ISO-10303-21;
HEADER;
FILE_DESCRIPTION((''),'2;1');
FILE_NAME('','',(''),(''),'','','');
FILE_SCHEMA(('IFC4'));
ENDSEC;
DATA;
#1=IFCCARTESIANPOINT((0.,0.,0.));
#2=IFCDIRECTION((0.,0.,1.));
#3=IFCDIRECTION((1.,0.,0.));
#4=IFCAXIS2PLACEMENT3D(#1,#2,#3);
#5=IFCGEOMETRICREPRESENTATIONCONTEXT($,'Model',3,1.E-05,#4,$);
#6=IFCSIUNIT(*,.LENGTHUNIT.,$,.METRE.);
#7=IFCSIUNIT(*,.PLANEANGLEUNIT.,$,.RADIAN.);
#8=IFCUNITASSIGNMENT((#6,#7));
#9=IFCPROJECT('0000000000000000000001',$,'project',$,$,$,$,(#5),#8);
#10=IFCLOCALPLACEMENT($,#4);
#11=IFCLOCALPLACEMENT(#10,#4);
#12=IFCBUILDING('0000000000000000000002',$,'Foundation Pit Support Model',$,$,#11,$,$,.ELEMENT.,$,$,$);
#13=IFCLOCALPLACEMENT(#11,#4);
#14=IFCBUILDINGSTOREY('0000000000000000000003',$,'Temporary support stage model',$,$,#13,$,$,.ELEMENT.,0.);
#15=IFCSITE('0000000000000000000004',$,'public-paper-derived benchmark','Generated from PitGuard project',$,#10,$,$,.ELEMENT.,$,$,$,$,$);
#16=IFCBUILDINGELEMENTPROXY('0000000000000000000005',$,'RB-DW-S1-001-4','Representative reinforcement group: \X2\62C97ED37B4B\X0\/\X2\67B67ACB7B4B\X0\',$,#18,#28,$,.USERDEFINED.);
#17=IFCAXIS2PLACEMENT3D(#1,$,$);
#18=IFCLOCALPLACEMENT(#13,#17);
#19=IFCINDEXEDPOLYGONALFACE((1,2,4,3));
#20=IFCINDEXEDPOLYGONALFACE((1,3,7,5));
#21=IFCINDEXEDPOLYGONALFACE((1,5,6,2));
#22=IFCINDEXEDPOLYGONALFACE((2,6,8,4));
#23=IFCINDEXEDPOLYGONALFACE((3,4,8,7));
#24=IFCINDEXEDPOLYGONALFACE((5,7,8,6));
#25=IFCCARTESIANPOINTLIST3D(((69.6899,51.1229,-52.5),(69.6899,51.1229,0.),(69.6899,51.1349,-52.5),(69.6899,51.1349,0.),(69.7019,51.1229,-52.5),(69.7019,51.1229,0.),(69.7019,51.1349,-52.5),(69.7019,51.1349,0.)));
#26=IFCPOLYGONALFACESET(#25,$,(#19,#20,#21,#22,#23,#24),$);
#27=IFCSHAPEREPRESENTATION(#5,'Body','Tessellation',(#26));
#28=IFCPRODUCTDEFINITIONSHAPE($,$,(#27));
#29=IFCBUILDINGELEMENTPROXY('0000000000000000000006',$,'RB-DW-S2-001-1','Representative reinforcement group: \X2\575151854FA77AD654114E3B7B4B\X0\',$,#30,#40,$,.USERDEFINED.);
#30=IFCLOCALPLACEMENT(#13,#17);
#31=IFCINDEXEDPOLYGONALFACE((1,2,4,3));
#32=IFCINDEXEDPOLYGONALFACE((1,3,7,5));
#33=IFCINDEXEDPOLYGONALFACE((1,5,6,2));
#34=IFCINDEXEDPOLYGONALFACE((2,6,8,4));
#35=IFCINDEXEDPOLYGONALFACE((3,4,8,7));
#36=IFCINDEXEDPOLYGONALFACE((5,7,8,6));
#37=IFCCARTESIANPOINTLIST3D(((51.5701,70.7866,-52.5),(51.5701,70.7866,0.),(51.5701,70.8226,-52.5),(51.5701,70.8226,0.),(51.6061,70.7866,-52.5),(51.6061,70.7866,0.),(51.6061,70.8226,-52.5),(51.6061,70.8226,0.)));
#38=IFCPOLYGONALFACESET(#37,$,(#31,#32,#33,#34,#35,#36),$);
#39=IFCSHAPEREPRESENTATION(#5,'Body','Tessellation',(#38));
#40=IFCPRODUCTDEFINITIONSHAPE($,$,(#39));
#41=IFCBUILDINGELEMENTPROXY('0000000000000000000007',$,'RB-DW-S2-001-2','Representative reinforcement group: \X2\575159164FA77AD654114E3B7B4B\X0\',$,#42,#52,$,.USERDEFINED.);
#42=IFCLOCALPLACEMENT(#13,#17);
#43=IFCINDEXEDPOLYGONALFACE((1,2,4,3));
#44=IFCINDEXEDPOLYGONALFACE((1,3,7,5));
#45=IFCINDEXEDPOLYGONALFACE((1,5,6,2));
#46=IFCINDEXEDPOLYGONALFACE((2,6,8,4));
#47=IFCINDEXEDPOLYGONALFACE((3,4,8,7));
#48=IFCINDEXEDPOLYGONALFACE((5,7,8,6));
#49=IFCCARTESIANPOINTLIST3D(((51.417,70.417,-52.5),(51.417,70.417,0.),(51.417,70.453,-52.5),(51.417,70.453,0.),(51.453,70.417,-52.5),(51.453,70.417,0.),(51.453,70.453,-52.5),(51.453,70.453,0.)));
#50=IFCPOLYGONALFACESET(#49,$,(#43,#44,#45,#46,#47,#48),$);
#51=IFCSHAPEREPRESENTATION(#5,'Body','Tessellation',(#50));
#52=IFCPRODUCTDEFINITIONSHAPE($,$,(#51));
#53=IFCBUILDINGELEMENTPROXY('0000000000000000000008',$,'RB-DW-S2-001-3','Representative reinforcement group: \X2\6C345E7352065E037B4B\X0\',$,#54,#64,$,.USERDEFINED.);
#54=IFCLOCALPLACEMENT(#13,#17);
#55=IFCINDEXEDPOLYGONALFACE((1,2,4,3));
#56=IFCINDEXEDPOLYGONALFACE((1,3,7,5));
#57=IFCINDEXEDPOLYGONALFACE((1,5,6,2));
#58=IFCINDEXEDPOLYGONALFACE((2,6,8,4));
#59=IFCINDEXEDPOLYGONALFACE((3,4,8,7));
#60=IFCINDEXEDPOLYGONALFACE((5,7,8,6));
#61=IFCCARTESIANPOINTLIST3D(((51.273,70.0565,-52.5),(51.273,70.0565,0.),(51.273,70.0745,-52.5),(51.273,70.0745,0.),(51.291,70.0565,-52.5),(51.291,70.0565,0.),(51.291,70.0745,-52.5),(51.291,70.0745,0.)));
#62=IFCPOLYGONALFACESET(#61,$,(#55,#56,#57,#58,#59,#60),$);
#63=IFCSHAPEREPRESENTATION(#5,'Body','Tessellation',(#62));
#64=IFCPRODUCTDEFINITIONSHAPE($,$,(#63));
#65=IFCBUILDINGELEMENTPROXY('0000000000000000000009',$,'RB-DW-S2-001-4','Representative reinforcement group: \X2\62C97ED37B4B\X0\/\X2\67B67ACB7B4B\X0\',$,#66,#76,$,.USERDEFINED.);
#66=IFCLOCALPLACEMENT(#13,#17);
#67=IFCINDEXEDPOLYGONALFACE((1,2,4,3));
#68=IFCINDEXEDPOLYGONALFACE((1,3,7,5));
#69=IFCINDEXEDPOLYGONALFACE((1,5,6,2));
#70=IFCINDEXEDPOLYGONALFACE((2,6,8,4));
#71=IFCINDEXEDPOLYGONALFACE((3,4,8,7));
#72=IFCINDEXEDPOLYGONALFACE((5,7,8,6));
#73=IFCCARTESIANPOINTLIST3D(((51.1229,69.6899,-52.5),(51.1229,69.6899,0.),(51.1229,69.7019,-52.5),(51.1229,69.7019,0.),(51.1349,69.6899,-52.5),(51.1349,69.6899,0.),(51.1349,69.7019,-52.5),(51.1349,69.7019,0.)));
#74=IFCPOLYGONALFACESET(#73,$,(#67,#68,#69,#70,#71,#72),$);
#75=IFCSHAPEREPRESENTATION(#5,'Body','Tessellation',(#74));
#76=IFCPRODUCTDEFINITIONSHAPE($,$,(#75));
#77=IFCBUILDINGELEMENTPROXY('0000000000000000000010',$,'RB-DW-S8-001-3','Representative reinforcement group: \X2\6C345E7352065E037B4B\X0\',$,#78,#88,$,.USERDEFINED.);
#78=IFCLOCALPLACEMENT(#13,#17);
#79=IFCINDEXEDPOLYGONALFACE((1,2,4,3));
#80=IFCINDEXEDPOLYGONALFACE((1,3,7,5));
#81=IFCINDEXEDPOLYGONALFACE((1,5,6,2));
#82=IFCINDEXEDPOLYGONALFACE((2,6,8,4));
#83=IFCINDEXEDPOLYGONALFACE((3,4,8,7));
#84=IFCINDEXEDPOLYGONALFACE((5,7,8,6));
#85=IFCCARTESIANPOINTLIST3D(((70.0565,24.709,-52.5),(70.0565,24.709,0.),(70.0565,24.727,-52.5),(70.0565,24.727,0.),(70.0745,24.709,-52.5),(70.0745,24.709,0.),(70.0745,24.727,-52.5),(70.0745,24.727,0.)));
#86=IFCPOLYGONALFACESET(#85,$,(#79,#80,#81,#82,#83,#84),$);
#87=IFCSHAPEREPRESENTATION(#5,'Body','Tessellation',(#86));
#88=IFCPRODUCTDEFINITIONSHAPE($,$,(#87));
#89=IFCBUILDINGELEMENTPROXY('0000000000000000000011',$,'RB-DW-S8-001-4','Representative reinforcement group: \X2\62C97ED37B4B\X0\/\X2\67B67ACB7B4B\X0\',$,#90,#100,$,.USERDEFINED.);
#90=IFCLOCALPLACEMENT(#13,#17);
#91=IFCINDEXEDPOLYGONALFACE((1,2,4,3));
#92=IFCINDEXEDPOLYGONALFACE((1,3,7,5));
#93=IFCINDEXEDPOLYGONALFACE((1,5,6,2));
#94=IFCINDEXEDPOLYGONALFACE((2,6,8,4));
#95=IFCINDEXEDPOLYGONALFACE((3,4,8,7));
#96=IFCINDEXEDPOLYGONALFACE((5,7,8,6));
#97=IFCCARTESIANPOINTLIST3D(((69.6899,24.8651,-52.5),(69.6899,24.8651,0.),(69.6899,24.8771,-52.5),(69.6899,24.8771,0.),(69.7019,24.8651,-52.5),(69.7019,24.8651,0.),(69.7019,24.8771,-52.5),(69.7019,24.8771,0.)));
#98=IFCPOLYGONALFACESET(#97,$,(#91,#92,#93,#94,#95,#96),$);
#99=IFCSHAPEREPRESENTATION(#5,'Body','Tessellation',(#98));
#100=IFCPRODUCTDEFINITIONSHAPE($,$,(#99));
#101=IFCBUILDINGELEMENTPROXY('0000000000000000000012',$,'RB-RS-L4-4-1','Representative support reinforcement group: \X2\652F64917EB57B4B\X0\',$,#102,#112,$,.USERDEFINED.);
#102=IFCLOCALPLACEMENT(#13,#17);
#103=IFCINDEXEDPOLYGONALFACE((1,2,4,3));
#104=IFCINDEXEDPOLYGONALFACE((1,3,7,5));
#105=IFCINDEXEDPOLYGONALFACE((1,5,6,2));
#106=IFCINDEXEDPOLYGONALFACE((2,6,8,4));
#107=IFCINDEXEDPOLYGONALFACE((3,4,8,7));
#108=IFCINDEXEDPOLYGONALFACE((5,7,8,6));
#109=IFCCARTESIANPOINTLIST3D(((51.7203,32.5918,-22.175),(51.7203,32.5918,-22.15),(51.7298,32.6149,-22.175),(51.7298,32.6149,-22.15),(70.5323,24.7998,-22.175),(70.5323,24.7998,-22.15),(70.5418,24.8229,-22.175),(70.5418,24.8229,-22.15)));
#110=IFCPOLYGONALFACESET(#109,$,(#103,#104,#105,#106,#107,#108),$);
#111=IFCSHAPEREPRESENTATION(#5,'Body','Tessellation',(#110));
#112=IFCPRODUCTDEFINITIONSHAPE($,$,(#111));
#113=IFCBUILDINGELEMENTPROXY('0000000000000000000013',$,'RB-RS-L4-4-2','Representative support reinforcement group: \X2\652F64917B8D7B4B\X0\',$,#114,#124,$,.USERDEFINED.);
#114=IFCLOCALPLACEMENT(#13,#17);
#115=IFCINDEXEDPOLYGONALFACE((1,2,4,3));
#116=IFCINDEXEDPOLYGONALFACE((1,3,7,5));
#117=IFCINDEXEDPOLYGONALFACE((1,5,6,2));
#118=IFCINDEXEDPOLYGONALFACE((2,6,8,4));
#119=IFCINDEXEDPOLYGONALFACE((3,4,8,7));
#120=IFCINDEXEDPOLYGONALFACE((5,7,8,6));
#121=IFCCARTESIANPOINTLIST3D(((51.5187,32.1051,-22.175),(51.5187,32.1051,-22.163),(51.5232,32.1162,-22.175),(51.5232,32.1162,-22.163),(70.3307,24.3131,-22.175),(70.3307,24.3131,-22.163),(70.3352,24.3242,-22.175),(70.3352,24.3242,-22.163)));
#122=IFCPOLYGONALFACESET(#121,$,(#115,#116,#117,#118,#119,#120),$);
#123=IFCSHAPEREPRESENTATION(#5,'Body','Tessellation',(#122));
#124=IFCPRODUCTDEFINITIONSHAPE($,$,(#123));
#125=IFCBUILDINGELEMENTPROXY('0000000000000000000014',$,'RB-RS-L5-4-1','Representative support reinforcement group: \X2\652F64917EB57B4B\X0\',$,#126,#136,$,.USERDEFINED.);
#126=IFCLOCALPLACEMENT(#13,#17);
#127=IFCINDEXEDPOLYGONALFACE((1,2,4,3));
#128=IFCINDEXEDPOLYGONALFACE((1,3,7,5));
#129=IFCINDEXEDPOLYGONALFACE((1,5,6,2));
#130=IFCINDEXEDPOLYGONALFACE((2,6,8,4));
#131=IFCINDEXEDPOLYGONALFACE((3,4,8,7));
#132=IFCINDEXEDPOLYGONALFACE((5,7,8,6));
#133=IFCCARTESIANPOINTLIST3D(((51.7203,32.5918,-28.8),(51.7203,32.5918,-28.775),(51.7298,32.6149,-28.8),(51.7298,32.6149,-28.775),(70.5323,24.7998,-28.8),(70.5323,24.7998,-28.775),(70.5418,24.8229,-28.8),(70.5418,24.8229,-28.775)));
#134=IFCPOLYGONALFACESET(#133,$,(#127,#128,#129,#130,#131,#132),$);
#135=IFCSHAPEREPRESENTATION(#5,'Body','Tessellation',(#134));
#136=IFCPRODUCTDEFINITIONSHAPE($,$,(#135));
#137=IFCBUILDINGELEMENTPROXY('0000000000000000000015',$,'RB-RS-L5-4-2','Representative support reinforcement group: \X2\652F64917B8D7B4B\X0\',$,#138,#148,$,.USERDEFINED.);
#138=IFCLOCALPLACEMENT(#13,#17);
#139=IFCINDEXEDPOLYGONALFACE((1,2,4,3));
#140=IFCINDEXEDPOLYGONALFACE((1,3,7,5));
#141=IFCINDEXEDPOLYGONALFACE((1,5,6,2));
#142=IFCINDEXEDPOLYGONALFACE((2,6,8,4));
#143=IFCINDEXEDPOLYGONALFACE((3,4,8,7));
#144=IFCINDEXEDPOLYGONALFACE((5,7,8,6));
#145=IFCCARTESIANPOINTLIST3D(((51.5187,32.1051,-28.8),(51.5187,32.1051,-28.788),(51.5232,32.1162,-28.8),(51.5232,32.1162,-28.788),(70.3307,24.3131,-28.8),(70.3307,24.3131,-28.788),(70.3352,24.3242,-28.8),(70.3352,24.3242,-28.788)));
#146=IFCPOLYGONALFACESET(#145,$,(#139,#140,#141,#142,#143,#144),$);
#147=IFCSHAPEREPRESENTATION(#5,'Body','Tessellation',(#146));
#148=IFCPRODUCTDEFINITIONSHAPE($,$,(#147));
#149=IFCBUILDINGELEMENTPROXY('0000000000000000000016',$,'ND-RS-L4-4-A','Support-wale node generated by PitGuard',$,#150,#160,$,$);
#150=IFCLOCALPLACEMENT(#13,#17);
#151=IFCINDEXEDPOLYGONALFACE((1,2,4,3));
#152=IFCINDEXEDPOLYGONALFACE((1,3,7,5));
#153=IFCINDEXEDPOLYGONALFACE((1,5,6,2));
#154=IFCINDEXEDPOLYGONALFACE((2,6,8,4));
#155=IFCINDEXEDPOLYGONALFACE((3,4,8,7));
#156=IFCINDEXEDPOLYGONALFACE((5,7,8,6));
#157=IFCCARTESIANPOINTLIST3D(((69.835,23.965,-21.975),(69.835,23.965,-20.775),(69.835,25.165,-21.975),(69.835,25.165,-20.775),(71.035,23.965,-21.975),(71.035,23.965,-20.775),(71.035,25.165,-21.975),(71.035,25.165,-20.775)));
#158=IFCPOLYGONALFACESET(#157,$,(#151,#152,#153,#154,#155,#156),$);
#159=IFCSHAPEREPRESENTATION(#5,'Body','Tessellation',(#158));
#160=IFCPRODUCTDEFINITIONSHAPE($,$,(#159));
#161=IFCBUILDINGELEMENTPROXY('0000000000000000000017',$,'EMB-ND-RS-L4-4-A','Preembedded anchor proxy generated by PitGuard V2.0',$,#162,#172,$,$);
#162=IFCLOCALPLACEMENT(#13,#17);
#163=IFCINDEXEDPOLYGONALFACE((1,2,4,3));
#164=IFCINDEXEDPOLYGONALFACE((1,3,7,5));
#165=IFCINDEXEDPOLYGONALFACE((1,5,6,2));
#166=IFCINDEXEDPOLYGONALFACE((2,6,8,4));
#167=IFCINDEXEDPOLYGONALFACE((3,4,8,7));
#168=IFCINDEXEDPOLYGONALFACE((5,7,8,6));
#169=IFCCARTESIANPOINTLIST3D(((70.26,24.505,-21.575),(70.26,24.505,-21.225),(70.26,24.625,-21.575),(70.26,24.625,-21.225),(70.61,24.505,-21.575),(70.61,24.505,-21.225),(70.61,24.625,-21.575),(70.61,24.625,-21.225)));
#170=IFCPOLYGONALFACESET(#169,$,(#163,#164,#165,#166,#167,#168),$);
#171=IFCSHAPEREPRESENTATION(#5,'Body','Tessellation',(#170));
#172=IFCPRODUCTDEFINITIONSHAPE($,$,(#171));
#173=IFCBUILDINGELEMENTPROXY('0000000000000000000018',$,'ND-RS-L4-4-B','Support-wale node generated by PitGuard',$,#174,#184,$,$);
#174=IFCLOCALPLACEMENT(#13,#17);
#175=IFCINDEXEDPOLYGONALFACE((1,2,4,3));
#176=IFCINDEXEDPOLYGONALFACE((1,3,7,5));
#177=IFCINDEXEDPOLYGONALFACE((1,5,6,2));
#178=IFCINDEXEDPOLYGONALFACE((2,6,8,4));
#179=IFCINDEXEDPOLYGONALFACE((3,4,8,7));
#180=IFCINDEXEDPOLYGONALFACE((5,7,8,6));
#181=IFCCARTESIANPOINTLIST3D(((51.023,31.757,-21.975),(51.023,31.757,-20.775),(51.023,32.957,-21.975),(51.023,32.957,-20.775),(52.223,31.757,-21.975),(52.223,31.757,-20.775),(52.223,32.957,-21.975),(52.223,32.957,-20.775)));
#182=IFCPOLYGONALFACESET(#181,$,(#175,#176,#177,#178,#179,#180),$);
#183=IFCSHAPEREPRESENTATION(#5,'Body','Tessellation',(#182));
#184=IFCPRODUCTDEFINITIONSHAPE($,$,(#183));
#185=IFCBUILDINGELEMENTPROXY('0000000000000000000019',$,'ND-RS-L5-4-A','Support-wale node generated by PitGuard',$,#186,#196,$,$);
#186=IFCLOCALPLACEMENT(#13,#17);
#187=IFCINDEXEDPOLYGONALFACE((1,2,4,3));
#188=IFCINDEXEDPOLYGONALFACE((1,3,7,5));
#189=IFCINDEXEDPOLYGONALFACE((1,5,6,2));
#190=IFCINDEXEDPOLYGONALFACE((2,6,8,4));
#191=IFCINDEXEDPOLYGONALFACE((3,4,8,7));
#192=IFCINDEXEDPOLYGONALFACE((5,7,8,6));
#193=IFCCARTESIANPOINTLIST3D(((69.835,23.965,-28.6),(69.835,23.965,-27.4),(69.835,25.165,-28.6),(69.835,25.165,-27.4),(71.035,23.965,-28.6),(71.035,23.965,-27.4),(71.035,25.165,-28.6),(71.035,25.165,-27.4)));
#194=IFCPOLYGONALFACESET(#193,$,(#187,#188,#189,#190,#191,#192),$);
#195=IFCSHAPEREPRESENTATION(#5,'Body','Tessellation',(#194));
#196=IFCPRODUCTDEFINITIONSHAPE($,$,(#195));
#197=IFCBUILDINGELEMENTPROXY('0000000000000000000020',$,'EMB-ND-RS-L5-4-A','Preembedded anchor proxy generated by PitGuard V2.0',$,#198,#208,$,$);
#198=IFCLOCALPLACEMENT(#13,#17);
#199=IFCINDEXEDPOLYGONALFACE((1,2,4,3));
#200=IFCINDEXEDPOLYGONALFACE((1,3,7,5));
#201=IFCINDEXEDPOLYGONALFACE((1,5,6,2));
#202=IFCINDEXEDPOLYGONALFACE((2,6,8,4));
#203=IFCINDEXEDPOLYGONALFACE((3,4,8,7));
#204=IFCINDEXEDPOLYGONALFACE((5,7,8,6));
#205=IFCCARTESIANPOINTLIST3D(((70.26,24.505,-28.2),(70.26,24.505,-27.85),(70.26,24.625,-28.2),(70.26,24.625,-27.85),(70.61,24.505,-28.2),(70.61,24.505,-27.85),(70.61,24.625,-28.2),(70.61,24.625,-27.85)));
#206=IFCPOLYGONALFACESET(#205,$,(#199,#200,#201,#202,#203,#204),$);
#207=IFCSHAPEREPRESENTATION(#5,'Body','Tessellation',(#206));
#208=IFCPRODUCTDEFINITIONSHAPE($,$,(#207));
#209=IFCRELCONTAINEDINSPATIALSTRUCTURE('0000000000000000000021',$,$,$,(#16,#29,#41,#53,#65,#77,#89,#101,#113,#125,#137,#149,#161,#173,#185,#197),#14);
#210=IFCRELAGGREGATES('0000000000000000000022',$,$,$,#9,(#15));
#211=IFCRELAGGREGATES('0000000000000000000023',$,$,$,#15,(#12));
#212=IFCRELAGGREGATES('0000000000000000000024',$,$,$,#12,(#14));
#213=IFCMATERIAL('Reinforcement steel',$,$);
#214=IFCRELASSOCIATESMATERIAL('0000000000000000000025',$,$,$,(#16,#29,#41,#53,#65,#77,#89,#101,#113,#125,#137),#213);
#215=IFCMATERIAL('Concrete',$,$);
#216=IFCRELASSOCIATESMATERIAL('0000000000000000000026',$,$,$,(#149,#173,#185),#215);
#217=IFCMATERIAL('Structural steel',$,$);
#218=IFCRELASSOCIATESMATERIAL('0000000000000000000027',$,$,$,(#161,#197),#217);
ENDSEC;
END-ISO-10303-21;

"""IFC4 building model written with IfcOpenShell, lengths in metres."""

from ifc_helpers import new_model, si_unit, frame, origin_with_axes, origin_2d, place, context, project, spatial, rectangle, extrude, material, element, save


model = new_model("IFC4")

# Units and contexts
model_context = context("Model", 3, precision=1e-05, world=origin_with_axes())
ifc_project = project(units=[si_unit("LENGTHUNIT", "METRE"), si_unit("PLANEANGLEUNIT", "RADIAN")], contexts=[model_context])

# Site, building, storey
site_placement = place(None, origin_with_axes())
site = spatial("IfcSite", under=ifc_project, at=site_placement, Name="public-paper-derived benchmark", Description="Generated from PitGuard project", CompositionType="ELEMENT")
building_placement = place(site_placement, origin_with_axes())
building = spatial("IfcBuilding", under=site, at=building_placement, Name="Foundation Pit Support Model", CompositionType="ELEMENT")
storey_placement = place(building_placement, origin_with_axes())
storey = spatial("IfcBuildingStorey", under=building, at=storey_placement, Name="Temporary support stage model", CompositionType="ELEMENT", Elevation=0.0)

# Shared definitions
ifc_material_1 = material(Name="Structural steel")

# Shared definitions
ifc_material_2 = material(Name="Concrete")

# Building element proxies
ifc_material_3 = material(Name="Reinforcement steel")
proxy_1_placement = place(storey_placement, frame((69.6959, 51.1289, -52.5), z_axis=(0.0, 0.0, 1.0), x_axis=(1.0, 0.0, 0.0)))
element("IfcBuildingElementProxy", 1, at=proxy_1_placement, inside=storey, material=ifc_material_3, Name="RB-DW-S1-001-4", Description="Representative reinforcement group: 拉结筋/架立筋", PredefinedType="USERDEFINED", context=model_context, shape_type="SweptSolid", body=[
    extrude(rectangle(XDim=0.012, YDim=0.012, at=origin_2d()), origin_with_axes(), (0.0, 0.0, 1.0), 52.5),
])
for number, where, z_axis, x_axis, name, description in (
    (2, (51.5881, 70.8046, -52.5), (0.0, 0.0, 1.0), (1.0, 0.0, 0.0), "RB-DW-S2-001-1", "Representative reinforcement group: 坑内侧竖向主筋"),
    (3, (51.435, 70.435, -52.5), (0.0, 0.0, 1.0), (1.0, 0.0, 0.0), "RB-DW-S2-001-2", "Representative reinforcement group: 坑外侧竖向主筋"),
):
    element("IfcBuildingElementProxy", number, at=place(storey_placement, frame(where, z_axis=z_axis, x_axis=x_axis)), inside=storey, material=ifc_material_3, Name=name, Description=description, PredefinedType="USERDEFINED", context=model_context, shape_type="SweptSolid", body=[
        extrude(rectangle(XDim=0.036, YDim=0.036, at=origin_2d()), origin_with_axes(), (0.0, 0.0, 1.0), 52.5),
    ])
proxy_2_placement = place(storey_placement, frame((51.282, 70.0655, -52.5), z_axis=(0.0, 0.0, 1.0), x_axis=(1.0, 0.0, 0.0)))
element("IfcBuildingElementProxy", 4, at=proxy_2_placement, inside=storey, material=ifc_material_3, Name="RB-DW-S2-001-3", Description="Representative reinforcement group: 水平分布筋", PredefinedType="USERDEFINED", context=model_context, shape_type="SweptSolid", body=[
    extrude(rectangle(XDim=0.018, YDim=0.018, at=origin_2d()), origin_with_axes(), (0.0, 0.0, 1.0), 52.5),
])
proxy_3_placement = place(storey_placement, frame((51.1289, 69.6959, -52.5), z_axis=(0.0, 0.0, 1.0), x_axis=(1.0, 0.0, 0.0)))
element("IfcBuildingElementProxy", 5, at=proxy_3_placement, inside=storey, material=ifc_material_3, Name="RB-DW-S2-001-4", Description="Representative reinforcement group: 拉结筋/架立筋", PredefinedType="USERDEFINED", context=model_context, shape_type="SweptSolid", body=[
    extrude(rectangle(XDim=0.012, YDim=0.012, at=origin_2d()), origin_with_axes(), (0.0, 0.0, 1.0), 52.5),
])
proxy_4_placement = place(storey_placement, frame((70.0655, 24.718, -52.5), z_axis=(0.0, 0.0, 1.0), x_axis=(1.0, 0.0, 0.0)))
element("IfcBuildingElementProxy", 6, at=proxy_4_placement, inside=storey, material=ifc_material_3, Name="RB-DW-S8-001-3", Description="Representative reinforcement group: 水平分布筋", PredefinedType="USERDEFINED", context=model_context, shape_type="SweptSolid", body=[
    extrude(rectangle(XDim=0.018, YDim=0.018, at=origin_2d()), origin_with_axes(), (0.0, 0.0, 1.0), 52.5),
])
proxy_5_placement = place(storey_placement, frame((69.6959, 24.8711, -52.5), z_axis=(0.0, 0.0, 1.0), x_axis=(1.0, 0.0, 0.0)))
element("IfcBuildingElementProxy", 7, at=proxy_5_placement, inside=storey, material=ifc_material_3, Name="RB-DW-S8-001-4", Description="Representative reinforcement group: 拉结筋/架立筋", PredefinedType="USERDEFINED", context=model_context, shape_type="SweptSolid", body=[
    extrude(rectangle(XDim=0.012, YDim=0.012, at=origin_2d()), origin_with_axes(), (0.0, 0.0, 1.0), 52.5),
])
proxy_6_placement = place(storey_placement, frame((61.131, 28.7074, -22.175), z_axis=(0.0, 0.0, 1.0), x_axis=(-0.923883, 0.382676, 0.0)))
element("IfcBuildingElementProxy", 8, at=proxy_6_placement, inside=storey, material=ifc_material_3, Name="RB-RS-L4-4-1", Description="Representative support reinforcement group: 支撑纵筋", PredefinedType="USERDEFINED", context=model_context, shape_type="SweptSolid", body=[
    extrude(rectangle(XDim=20.3619, YDim=0.025, at=origin_2d()), origin_with_axes(), (0.0, 0.0, 1.0), 0.025),
])
proxy_7_placement = place(storey_placement, frame((60.927, 28.2146, -22.175), z_axis=(0.0, 0.0, 1.0), x_axis=(-0.923883, 0.382676, 0.0)))
element("IfcBuildingElementProxy", 9, at=proxy_7_placement, inside=storey, material=ifc_material_3, Name="RB-RS-L4-4-2", Description="Representative support reinforcement group: 支撑箍筋", PredefinedType="USERDEFINED", context=model_context, shape_type="SweptSolid", body=[
    extrude(rectangle(XDim=20.3619, YDim=0.012, at=origin_2d()), origin_with_axes(), (0.0, 0.0, 1.0), 0.012),
])
proxy_8_placement = place(storey_placement, frame((61.131, 28.7074, -28.8), z_axis=(0.0, 0.0, 1.0), x_axis=(-0.923883, 0.382676, 0.0)))
element("IfcBuildingElementProxy", 10, at=proxy_8_placement, inside=storey, material=ifc_material_3, Name="RB-RS-L5-4-1", Description="Representative support reinforcement group: 支撑纵筋", PredefinedType="USERDEFINED", context=model_context, shape_type="SweptSolid", body=[
    extrude(rectangle(XDim=20.3619, YDim=0.025, at=origin_2d()), origin_with_axes(), (0.0, 0.0, 1.0), 0.025),
])
proxy_9_placement = place(storey_placement, frame((60.927, 28.2146, -28.8), z_axis=(0.0, 0.0, 1.0), x_axis=(-0.923883, 0.382676, 0.0)))
element("IfcBuildingElementProxy", 11, at=proxy_9_placement, inside=storey, material=ifc_material_3, Name="RB-RS-L5-4-2", Description="Representative support reinforcement group: 支撑箍筋", PredefinedType="USERDEFINED", context=model_context, shape_type="SweptSolid", body=[
    extrude(rectangle(XDim=20.3619, YDim=0.012, at=origin_2d()), origin_with_axes(), (0.0, 0.0, 1.0), 0.012),
])
proxy_10_placement = place(storey_placement, frame((70.435, 24.565, -21.975), z_axis=(0.0, 0.0, 1.0), x_axis=(1.0, 0.0, 0.0)))
element("IfcBuildingElementProxy", 12, at=proxy_10_placement, inside=storey, material=ifc_material_2, Name="ND-RS-L4-4-A", Description="Support-wale node generated by PitGuard", context=model_context, shape_type="SweptSolid", body=[
    extrude(rectangle(XDim=1.2, YDim=1.2, at=origin_2d()), origin_with_axes(), (0.0, 0.0, 1.0), 1.2),
])
proxy_11_placement = place(storey_placement, frame((70.435, 24.565, -21.575), z_axis=(0.0, 0.0, 1.0), x_axis=(1.0, 0.0, 0.0)))
element("IfcBuildingElementProxy", 13, at=proxy_11_placement, inside=storey, material=ifc_material_1, Name="EMB-ND-RS-L4-4-A", Description="Preembedded anchor proxy generated by PitGuard V2.0", context=model_context, shape_type="SweptSolid", body=[
    extrude(rectangle(XDim=0.35, YDim=0.12, at=origin_2d()), origin_with_axes(), (0.0, 0.0, 1.0), 0.35),
])
for number, where, z_axis, x_axis, name in (
    (14, (51.623, 32.357, -21.975), (0.0, 0.0, 1.0), (1.0, 0.0, 0.0), "ND-RS-L4-4-B"),
    (15, (70.435, 24.565, -28.6), (0.0, 0.0, 1.0), (1.0, 0.0, 0.0), "ND-RS-L5-4-A"),
):
    element("IfcBuildingElementProxy", number, at=place(storey_placement, frame(where, z_axis=z_axis, x_axis=x_axis)), inside=storey, material=ifc_material_2, Name=name, Description="Support-wale node generated by PitGuard", context=model_context, shape_type="SweptSolid", body=[
        extrude(rectangle(XDim=1.2, YDim=1.2, at=origin_2d()), origin_with_axes(), (0.0, 0.0, 1.0), 1.2),
    ])
proxy_12_placement = place(storey_placement, frame((70.435, 24.565, -28.2), z_axis=(0.0, 0.0, 1.0), x_axis=(1.0, 0.0, 0.0)))
element("IfcBuildingElementProxy", 16, at=proxy_12_placement, inside=storey, material=ifc_material_1, Name="EMB-ND-RS-L5-4-A", Description="Preembedded anchor proxy generated by PitGuard V2.0", context=model_context, shape_type="SweptSolid", body=[
    extrude(rectangle(XDim=0.35, YDim=0.12, at=origin_2d()), origin_with_axes(), (0.0, 0.0, 1.0), 0.35),
])

save(model, "model.ifc")
